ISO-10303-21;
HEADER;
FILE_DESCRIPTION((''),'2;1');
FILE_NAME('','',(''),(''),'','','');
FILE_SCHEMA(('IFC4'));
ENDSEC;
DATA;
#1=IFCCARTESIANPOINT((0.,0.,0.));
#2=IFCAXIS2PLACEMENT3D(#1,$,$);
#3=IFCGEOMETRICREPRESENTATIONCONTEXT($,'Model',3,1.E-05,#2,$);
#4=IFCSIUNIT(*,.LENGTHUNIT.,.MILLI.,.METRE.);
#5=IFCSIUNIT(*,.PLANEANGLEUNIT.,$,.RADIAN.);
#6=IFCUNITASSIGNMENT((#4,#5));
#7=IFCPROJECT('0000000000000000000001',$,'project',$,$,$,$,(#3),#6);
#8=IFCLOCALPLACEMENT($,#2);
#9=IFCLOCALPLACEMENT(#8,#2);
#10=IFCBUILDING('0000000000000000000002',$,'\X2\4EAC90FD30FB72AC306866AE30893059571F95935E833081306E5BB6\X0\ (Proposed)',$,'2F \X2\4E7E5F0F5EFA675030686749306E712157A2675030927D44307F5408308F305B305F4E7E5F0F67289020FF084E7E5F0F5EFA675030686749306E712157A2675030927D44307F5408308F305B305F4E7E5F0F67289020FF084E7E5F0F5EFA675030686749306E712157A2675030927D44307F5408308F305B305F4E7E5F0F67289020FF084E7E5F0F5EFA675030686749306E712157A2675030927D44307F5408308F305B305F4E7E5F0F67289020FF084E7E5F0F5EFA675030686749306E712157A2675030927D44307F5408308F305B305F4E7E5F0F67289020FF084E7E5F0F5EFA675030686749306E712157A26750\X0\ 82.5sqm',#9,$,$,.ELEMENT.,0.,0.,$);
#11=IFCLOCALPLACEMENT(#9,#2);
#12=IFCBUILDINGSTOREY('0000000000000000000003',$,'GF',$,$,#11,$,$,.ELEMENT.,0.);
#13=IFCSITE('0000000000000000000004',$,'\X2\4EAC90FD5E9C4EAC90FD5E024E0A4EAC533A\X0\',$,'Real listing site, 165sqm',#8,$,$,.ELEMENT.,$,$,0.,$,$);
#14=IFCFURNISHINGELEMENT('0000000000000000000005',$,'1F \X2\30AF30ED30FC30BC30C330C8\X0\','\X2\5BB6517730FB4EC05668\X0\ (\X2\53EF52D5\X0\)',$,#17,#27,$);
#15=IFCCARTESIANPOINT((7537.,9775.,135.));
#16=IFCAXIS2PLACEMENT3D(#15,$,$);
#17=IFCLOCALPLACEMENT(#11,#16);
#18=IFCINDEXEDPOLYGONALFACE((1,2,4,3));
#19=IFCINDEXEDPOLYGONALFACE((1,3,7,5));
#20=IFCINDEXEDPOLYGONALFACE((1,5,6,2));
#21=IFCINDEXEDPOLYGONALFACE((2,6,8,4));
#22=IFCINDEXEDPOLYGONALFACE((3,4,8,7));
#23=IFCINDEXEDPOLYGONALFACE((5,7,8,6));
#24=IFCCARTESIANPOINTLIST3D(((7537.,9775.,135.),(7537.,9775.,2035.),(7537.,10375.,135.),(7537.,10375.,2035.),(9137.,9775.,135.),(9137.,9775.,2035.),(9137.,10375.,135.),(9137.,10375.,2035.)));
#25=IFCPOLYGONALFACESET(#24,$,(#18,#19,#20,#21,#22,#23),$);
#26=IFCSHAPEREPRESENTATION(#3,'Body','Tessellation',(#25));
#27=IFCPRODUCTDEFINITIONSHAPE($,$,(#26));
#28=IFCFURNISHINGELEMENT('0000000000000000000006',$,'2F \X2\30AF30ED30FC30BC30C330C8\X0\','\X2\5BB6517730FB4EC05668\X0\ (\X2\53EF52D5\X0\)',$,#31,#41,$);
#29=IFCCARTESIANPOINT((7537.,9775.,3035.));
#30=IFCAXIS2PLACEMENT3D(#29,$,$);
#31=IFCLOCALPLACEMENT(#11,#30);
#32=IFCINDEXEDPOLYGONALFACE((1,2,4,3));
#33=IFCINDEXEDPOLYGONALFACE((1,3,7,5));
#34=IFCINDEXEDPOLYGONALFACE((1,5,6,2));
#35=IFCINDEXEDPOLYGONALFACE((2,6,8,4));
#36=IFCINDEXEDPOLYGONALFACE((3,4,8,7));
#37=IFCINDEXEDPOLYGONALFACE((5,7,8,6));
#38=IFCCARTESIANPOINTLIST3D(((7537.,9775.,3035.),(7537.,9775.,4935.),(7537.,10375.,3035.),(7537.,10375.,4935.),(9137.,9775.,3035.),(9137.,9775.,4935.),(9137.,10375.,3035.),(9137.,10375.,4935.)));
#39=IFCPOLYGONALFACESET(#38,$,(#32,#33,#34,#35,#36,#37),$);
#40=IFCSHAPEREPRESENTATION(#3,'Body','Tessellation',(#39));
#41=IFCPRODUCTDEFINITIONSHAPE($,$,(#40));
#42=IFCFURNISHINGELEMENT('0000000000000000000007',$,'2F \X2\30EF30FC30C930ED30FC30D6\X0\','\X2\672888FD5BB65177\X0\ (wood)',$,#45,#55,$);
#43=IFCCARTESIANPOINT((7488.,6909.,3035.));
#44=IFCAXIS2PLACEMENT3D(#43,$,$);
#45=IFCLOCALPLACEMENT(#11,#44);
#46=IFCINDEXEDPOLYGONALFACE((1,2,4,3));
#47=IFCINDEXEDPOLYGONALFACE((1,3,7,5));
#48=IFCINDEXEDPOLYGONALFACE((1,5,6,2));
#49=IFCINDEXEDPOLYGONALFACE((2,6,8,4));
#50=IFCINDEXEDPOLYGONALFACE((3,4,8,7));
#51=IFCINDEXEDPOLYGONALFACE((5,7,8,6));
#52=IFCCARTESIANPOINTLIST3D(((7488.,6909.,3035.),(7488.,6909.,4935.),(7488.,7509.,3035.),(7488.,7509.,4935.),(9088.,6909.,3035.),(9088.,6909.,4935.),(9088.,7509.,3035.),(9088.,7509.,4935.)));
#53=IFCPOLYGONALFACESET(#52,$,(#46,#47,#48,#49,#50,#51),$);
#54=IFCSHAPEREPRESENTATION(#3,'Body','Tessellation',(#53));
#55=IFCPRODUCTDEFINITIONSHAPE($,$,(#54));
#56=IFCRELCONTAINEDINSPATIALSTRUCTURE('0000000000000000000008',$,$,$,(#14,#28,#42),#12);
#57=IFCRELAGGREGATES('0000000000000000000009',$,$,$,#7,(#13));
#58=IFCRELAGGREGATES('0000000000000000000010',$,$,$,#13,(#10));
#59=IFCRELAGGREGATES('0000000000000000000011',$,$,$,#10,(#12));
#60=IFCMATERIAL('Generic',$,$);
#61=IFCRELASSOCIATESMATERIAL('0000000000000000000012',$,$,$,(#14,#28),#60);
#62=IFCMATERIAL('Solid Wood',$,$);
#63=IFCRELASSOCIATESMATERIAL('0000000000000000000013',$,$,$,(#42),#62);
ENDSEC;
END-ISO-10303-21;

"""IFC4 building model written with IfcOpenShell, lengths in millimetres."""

from ifc_helpers import new_model, si_unit, frame, frame_2d, origin, place, context, project, spatial, rectangle, extrude, material, element, save


model = new_model("IFC4")

# Units and contexts
model_context = context("Model", 3, precision=1e-05, world=origin())
ifc_project = project(units=[si_unit("LENGTHUNIT", "METRE", prefix="MILLI"), si_unit("PLANEANGLEUNIT", "RADIAN")], contexts=[model_context])

# Site, building, storey
site_placement = place(None, origin())
site = spatial("IfcSite", under=ifc_project, at=site_placement, Name="京都府京都市上京区", ObjectType="Real listing site, 165sqm", CompositionType="ELEMENT", RefElevation=0.0)
building_placement = place(site_placement, origin())
building = spatial("IfcBuilding", under=site, at=building_placement, Name="京都・犬と暮らす土間広めの家 (Proposed)", ObjectType="2F 乾式建材と杉の無垢材を組み合わせた乾式木造（乾式建材と杉の無垢材を組み合わせた乾式木造（乾式建材と杉の無垢材を組み合わせた乾式木造（乾式建材と杉の無垢材を組み合わせた乾式木造（乾式建材と杉の無垢材を組み合わせた乾式木造（乾式建材と杉の無垢材 82.5sqm", CompositionType="ELEMENT", ElevationOfRefHeight=0.0, ElevationOfTerrain=0.0)
storey_placement = place(building_placement, origin())
storey = spatial("IfcBuildingStorey", under=building, at=storey_placement, Name="GF", CompositionType="ELEMENT", Elevation=0.0)

# Shared definitions
ifc_material_1 = material(Name="Solid Wood")

# Shared definitions
ifc_material_2 = material(Name="Generic")

# Furnishing elements
furnishing_1_placement = place(storey_placement, frame((7537.0, 9775.0, 135.0)))
element("IfcFurnishingElement", 1, at=furnishing_1_placement, inside=storey, material=ifc_material_2, Name="1F クローゼット", Description="家具・什器 (可動)", context=model_context, shape_type="SweptSolid", body=[
    extrude(rectangle(XDim=1600.0, YDim=600.0, at=frame_2d((800.0, 300.0))), frame((7537.0, 9775.0, 135.0)), (0.0, 0.0, 1.0), 1900.0),
])
furnishing_2_placement = place(storey_placement, frame((7537.0, 9775.0, 3035.0)))
element("IfcFurnishingElement", 2, at=furnishing_2_placement, inside=storey, material=ifc_material_2, Name="2F クローゼット", Description="家具・什器 (可動)", context=model_context, shape_type="SweptSolid", body=[
    extrude(rectangle(XDim=1600.0, YDim=600.0, at=frame_2d((800.0, 300.0))), frame((7537.0, 9775.0, 3035.0)), (0.0, 0.0, 1.0), 1900.0),
])
furnishing_3_placement = place(storey_placement, frame((7488.0, 6909.0, 3035.0)))
element("IfcFurnishingElement", 3, at=furnishing_3_placement, inside=storey, material=ifc_material_1, Name="2F ワードローブ", Description="木製家具 (wood)", context=model_context, shape_type="SweptSolid", body=[
    extrude(rectangle(XDim=1600.0, YDim=600.0, at=frame_2d((800.0, 300.0))), frame((7488.0, 6909.0, 3035.0)), (0.0, 0.0, 1.0), 1900.0),
])

save(model, "model.ifc")
